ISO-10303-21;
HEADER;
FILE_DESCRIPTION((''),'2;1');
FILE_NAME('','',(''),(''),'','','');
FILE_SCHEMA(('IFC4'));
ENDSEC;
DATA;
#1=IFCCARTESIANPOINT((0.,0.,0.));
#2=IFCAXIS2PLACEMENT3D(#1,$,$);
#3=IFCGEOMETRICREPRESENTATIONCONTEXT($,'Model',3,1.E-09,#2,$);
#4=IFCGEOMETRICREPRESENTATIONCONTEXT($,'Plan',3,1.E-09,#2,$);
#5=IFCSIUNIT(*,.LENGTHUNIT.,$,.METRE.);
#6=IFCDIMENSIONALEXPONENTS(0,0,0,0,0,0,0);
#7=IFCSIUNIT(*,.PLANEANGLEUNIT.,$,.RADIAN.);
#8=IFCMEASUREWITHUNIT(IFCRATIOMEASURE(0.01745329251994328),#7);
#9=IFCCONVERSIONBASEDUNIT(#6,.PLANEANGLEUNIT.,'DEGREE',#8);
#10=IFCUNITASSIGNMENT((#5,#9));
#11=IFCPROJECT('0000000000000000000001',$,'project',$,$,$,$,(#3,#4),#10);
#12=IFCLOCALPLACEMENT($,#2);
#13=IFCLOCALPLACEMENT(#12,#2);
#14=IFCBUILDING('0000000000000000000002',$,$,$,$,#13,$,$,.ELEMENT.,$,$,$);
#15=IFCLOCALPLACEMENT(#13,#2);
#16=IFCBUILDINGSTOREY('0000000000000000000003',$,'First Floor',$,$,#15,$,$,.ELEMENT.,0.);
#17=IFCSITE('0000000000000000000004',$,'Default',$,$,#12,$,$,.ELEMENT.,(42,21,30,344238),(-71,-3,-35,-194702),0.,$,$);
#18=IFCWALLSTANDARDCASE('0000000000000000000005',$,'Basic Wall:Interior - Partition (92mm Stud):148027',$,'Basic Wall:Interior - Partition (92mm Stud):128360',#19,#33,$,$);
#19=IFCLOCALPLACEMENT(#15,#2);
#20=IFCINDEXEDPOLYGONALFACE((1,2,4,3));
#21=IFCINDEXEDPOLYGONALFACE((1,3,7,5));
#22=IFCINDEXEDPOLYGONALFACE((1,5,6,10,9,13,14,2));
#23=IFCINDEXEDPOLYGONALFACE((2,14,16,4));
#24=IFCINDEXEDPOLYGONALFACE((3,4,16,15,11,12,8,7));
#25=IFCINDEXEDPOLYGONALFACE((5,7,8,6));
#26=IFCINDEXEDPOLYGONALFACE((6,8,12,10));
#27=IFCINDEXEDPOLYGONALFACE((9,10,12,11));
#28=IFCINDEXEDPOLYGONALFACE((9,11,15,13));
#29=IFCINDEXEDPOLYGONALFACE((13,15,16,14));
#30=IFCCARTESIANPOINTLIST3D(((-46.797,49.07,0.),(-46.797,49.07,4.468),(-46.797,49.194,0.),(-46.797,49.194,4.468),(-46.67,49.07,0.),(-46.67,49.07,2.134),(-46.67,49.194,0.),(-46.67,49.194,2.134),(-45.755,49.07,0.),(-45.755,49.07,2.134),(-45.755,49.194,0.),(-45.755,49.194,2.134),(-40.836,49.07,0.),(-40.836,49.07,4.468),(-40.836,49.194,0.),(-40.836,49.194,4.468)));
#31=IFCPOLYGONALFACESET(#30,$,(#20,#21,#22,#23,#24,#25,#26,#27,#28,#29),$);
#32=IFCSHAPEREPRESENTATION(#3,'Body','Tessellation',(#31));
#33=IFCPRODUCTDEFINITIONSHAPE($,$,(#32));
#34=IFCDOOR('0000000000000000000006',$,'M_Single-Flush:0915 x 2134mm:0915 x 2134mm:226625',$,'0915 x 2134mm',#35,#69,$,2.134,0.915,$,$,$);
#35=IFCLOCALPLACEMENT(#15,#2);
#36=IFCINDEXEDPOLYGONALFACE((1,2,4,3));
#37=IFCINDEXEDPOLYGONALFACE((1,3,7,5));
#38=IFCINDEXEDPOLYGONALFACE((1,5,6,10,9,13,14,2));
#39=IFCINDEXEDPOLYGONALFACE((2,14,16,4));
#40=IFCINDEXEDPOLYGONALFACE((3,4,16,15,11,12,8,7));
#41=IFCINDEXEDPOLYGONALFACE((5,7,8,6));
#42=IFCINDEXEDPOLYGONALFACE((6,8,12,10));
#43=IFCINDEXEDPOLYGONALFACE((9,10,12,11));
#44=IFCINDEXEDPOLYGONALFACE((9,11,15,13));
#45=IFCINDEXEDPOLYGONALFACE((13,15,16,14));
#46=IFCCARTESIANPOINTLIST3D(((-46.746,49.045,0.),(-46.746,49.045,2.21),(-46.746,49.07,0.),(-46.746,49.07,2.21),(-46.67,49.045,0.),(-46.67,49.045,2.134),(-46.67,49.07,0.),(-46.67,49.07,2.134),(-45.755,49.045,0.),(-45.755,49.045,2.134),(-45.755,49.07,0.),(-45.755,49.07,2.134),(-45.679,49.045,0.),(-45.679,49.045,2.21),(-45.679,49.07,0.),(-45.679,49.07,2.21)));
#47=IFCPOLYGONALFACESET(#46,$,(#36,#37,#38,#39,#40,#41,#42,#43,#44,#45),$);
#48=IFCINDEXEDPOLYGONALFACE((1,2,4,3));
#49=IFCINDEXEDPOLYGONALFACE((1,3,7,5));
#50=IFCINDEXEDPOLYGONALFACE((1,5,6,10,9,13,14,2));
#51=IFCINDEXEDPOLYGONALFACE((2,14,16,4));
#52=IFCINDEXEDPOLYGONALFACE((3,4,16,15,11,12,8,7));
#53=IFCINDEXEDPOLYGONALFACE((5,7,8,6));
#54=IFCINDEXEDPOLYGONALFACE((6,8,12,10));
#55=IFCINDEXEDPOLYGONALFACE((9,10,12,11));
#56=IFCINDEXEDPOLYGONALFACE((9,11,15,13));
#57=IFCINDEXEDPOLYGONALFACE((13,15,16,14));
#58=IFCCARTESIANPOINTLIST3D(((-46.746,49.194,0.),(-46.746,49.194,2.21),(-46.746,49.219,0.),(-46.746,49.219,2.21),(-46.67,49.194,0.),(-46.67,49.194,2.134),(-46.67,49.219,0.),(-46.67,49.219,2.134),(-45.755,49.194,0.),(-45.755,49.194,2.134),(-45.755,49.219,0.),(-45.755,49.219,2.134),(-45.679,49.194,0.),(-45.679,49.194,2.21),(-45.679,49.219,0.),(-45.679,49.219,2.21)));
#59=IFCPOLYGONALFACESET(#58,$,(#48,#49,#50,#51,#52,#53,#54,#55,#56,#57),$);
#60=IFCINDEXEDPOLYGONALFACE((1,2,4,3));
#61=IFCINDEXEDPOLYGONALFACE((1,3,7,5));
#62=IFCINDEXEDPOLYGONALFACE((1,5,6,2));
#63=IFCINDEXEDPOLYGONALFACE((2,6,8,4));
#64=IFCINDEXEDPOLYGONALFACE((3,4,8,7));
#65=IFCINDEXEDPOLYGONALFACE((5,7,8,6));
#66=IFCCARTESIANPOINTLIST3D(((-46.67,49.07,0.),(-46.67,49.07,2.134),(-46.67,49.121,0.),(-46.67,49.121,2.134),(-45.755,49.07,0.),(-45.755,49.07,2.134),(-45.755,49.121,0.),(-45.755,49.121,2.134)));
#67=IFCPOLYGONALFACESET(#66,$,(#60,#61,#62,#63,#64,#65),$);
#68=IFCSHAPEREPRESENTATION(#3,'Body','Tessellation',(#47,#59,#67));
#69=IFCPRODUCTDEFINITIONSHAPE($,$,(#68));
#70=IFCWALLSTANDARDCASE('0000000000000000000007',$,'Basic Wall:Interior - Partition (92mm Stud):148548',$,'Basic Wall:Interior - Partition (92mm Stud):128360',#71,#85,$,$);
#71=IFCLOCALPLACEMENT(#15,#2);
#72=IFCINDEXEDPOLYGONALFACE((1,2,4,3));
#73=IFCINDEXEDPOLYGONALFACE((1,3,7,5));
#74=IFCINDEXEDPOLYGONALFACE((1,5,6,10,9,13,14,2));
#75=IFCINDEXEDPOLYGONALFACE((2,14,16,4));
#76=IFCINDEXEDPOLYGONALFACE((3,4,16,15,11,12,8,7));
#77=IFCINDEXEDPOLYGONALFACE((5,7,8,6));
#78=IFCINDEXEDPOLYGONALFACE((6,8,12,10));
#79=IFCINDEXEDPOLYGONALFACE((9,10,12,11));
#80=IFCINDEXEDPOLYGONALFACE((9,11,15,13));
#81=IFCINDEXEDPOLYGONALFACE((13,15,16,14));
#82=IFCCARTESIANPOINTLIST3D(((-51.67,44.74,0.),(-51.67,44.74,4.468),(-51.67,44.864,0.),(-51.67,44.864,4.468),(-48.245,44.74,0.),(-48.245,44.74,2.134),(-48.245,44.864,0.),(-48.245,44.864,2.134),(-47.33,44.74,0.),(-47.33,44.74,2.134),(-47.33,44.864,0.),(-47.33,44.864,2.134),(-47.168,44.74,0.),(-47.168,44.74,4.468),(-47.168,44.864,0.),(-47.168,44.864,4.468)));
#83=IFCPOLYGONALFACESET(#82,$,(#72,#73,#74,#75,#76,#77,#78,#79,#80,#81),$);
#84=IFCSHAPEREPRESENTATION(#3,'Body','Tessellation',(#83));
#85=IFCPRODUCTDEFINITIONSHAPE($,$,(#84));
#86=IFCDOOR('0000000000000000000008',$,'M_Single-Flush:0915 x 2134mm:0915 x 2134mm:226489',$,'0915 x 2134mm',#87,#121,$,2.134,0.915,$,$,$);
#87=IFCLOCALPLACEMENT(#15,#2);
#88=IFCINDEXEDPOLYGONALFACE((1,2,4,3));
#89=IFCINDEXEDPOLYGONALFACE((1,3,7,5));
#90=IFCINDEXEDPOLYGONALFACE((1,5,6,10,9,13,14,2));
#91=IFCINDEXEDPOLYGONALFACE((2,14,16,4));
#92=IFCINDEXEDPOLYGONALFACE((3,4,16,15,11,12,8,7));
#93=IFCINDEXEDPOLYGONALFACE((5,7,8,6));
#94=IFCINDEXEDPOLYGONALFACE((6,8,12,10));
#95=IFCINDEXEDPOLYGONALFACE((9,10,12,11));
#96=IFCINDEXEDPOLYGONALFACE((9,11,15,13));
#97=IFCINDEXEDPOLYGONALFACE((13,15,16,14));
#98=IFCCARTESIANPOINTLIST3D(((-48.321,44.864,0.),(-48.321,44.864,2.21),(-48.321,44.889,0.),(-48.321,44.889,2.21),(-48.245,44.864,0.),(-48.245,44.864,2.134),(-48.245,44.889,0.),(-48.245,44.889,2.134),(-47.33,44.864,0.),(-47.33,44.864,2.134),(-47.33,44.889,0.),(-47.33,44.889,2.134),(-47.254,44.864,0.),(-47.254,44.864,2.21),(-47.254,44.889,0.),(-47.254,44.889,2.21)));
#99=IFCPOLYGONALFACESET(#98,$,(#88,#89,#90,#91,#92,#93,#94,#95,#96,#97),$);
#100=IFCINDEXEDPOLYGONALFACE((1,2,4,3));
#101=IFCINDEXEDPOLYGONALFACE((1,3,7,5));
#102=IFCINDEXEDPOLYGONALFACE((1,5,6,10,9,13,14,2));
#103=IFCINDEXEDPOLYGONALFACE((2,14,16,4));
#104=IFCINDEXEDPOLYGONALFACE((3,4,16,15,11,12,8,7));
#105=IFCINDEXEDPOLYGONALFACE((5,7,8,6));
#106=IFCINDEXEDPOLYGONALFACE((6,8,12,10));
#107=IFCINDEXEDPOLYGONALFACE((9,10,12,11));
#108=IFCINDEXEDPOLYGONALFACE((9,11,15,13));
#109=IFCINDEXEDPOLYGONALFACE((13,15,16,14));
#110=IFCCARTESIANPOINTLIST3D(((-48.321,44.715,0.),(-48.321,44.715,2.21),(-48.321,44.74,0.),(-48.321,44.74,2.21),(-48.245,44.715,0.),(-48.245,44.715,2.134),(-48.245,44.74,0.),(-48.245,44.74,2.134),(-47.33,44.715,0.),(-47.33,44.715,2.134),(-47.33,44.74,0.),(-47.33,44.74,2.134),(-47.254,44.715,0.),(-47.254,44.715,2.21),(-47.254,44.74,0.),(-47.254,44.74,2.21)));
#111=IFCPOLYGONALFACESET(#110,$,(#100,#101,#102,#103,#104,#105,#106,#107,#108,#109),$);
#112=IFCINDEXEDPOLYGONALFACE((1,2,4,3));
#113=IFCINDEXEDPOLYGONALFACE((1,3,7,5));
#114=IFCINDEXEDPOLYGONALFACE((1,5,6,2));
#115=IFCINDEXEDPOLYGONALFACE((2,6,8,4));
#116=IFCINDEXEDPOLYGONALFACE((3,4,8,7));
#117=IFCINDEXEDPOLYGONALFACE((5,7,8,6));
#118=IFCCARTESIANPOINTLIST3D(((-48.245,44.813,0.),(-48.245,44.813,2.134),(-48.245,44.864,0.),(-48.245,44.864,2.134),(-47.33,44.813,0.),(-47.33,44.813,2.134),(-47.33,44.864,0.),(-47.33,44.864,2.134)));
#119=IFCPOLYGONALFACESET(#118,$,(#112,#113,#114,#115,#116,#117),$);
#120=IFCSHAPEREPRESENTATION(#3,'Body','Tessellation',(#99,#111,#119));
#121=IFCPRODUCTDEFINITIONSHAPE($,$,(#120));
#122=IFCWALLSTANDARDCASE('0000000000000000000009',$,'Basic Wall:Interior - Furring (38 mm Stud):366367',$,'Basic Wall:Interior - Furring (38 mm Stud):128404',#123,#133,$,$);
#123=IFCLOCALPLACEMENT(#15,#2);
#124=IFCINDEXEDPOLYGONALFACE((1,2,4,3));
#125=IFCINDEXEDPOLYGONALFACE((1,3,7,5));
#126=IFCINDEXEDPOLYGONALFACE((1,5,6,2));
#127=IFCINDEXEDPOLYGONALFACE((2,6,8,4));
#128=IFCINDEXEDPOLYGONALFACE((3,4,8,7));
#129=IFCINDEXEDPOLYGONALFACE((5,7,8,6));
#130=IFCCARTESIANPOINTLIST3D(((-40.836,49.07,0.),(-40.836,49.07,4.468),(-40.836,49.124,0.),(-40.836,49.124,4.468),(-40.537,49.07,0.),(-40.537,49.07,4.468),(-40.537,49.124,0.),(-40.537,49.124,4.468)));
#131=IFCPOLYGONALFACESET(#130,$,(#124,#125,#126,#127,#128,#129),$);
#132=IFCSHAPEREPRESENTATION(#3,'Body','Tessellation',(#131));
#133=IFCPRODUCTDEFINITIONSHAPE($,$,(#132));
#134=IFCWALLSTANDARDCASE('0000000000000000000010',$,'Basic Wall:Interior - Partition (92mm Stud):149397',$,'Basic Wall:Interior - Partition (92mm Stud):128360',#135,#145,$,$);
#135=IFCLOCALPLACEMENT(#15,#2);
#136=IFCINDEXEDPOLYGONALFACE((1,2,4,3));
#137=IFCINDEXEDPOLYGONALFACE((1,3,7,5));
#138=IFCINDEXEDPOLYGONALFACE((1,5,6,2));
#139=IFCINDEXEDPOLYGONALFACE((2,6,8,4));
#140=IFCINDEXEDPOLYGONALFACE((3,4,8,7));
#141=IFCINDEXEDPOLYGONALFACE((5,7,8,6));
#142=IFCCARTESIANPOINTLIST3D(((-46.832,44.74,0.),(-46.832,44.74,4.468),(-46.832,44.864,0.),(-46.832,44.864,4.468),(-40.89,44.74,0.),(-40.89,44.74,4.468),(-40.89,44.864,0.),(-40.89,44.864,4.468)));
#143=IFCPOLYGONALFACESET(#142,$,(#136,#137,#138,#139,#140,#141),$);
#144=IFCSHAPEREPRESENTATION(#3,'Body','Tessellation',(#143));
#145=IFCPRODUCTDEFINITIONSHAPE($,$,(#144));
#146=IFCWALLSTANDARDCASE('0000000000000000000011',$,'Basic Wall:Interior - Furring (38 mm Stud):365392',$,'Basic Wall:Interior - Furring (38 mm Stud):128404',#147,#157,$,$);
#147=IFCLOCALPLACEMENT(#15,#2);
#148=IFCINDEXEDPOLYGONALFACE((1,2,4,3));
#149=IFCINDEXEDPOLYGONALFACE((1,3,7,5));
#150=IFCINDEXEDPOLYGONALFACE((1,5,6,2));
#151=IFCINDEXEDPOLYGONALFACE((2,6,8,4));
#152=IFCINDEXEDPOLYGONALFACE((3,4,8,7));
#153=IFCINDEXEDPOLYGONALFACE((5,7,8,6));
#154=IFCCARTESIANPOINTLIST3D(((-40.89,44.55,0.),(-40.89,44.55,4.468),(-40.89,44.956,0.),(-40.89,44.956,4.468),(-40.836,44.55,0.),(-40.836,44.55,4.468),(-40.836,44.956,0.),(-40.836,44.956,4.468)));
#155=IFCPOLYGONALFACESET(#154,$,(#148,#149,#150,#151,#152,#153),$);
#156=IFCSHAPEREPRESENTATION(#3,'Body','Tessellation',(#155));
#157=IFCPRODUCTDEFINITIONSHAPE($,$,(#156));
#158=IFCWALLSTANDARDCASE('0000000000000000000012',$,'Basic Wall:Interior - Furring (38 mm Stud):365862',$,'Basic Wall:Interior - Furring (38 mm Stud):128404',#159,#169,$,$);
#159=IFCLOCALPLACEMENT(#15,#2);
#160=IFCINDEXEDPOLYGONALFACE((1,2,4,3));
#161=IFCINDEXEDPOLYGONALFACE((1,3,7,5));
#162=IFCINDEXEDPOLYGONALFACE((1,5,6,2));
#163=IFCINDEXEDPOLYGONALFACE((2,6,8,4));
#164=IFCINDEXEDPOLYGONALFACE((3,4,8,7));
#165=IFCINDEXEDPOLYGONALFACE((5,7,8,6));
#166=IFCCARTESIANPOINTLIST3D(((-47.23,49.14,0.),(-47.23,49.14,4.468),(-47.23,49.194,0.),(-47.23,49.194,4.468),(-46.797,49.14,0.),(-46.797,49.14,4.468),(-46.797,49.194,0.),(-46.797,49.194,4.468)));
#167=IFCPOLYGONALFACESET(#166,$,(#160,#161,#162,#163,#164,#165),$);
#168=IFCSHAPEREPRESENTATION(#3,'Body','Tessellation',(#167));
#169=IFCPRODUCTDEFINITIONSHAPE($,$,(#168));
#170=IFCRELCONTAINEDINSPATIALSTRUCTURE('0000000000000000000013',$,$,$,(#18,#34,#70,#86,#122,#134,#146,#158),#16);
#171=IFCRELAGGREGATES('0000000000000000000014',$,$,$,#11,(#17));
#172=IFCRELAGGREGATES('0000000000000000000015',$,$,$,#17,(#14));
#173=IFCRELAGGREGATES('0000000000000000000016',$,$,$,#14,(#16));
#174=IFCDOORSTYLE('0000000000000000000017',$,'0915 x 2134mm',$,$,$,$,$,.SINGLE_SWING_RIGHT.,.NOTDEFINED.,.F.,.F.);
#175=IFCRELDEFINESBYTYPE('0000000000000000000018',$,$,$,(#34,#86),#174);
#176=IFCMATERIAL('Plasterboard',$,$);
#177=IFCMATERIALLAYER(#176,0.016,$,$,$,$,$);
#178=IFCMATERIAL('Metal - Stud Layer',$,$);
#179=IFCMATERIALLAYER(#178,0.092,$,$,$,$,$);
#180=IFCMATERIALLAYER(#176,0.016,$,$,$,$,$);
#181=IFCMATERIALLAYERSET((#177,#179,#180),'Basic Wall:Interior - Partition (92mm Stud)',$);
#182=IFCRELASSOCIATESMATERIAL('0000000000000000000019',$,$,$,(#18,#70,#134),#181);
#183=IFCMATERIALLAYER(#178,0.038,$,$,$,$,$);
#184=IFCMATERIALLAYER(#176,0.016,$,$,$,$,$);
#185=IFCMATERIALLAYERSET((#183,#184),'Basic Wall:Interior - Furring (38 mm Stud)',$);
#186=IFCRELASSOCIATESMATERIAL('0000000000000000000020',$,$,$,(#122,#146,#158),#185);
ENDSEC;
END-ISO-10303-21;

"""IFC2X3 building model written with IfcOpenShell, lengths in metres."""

from ifc_helpers import new_model, entity, si_unit, converted_unit, frame, frame_2d, origin, origin_2d_with_axis, place, context, project, spatial, polyline, rectangle, outline, extrude, source, transform, mapped, material, layer, layer_set, layer_usage, type_object, type_shapes, element, fill, save


model = new_model("IFC2X3")

# Units and contexts
model_context = context("Model", 3, precision=1e-09, world=origin())
plan_context = context("Plan", 3, precision=1e-09, world=origin())
ifc_project = project(units=[si_unit("LENGTHUNIT", "METRE"), converted_unit("PLANEANGLEUNIT", "DEGREE", entity("IfcRatioMeasure", 0.01745329251994328), si_unit("PLANEANGLEUNIT", "RADIAN"), dimensions=[0, 0, 0, 0, 0, 0, 0])], contexts=[model_context, plan_context])

# Site, building, storey
site_placement = place(None, origin())
site = spatial("IfcSite", under=ifc_project, at=site_placement, Name="Default", CompositionType="ELEMENT", RefLatitude=(42, 21, 30, 344238), RefLongitude=(-71, -3, -35, -194702), RefElevation=0.0)
building_placement = place(site_placement, origin())
building = spatial("IfcBuilding", under=site, at=building_placement, CompositionType="ELEMENT")
storey_placement = place(building_placement, origin())
storey = spatial("IfcBuildingStorey", under=building, at=storey_placement, Name="First Floor", CompositionType="ELEMENT", Elevation=0.0)

# Walls, openings, doors
ifc_material_1 = material(Name="Plasterboard")
ifc_layer_1 = layer(ifc_material_1, 0.016)
ifc_material_2 = material(Name="Metal - Stud Layer")
ifc_layer_2 = layer(ifc_material_2, 0.092)
ifc_layer_3 = layer(ifc_material_1, 0.016)
ifc_layer_set_1 = layer_set([ifc_layer_1, ifc_layer_2, ifc_layer_3], Name="Basic Wall:Interior - Partition (92mm Stud)")
ifc_layer_usage_1 = layer_usage(ifc_layer_set_1, "AXIS2", "NEGATIVE", 0.062)
wall_1_placement = place(storey_placement, frame((-40.836, 49.132, 0.0), z_axis=(0.0, 0.0, 1.0), x_axis=(-1.0, 0.0, 0.0)))
wall_1 = element("IfcWallStandardCase", 1, at=wall_1_placement, inside=storey, material=ifc_layer_usage_1, Name="Basic Wall:Interior - Partition (92mm Stud):148027", ObjectType="Basic Wall:Interior - Partition (92mm Stud):128360", context=model_context, shape_type="SweptSolid", body=[
    extrude(rectangle(XDim=5.961, YDim=0.124, at=frame_2d((2.9805, 0.0), x_axis=(-1.0, 0.0))), origin(), (0.0, 0.0, 1.0), 4.468),
])
opening_1_placement = place(wall_1_placement, frame((4.919, -0.062, 0.0)))
opening_1 = element("IfcOpeningElement", 2, at=opening_1_placement, cuts=wall_1, ObjectType="Opening", context=model_context, shape_type="SweptSolid", body=[
    extrude(rectangle(XDim=0.915, YDim=2.134, at=frame_2d((1.067, 0.4575), x_axis=(0.0, 1.0))), frame((0.0, 0.0, 0.0), z_axis=(0.0, 1.0, 0.0), x_axis=(0.0, 0.0, 1.0)), (0.0, 0.0, 1.0), 0.124),
])
door_style_1 = type_object("IfcDoorStyle", Name="0915 x 2134mm", ConstructionType="NOTDEFINED", OperationType="SINGLE_SWING_RIGHT", ParameterTakesPrecedence=False, Sizeable=False)
shared_shape_1 = source(origin(), model_context, "Body", "SweptSolid", [
    extrude(outline(polyline([(-0.5335, -1.124), (0.5335, -1.124), (0.5335, 1.086), (0.4575, 1.086), (0.4575, -1.048), (-0.4575, -1.048), (-0.4575, 1.086), (-0.5335, 1.086), (-0.5335, -1.124)])), frame((0.4575, 0.124, 1.086), z_axis=(0.0, 1.0, 0.0), x_axis=(1.0, 0.0, 0.0)), (0.0, 0.0, 1.0), 0.025),
    extrude(outline(polyline([(-1.124, -0.5335), (1.086, -0.5335), (1.086, -0.4575), (-1.048, -0.4575), (-1.048, 0.4575), (1.086, 0.4575), (1.086, 0.5335), (-1.124, 0.5335), (-1.124, -0.5335)])), frame((0.4575, -0.025, 1.086), z_axis=(0.0, 1.0, 0.0), x_axis=(0.0, 0.0, -1.0)), (0.0, 0.0, 1.0), 0.025),
    extrude(rectangle(XDim=0.051, YDim=0.915, at=origin_2d_with_axis()), frame((0.4575, 0.0985, 0.0), z_axis=(0.0, 0.0, 1.0), x_axis=(0.0, 1.0, 0.0)), (0.0, 0.0, 1.0), 2.134),
])
type_shapes(door_style_1, [shared_shape_1])
door_1_placement = place(opening_1_placement, origin())
door_1 = element("IfcDoor", 3, at=door_1_placement, inside=storey, type_object=door_style_1, Name="M_Single-Flush:0915 x 2134mm:0915 x 2134mm:226625", ObjectType="0915 x 2134mm", OverallHeight=2.134, OverallWidth=0.915, context=model_context, shape_type="MappedRepresentation", body=[
    mapped(shared_shape_1, transform((0.0, 0.0, 0.0), scale=1.0)),
])
fill(opening_1, door_1)
wall_2_placement = place(storey_placement, frame((-47.168, 44.802, 0.0), z_axis=(0.0, 0.0, 1.0), x_axis=(-1.0, 0.0, 0.0)))
wall_2 = element("IfcWallStandardCase", 4, at=wall_2_placement, inside=storey, material=ifc_layer_usage_1, Name="Basic Wall:Interior - Partition (92mm Stud):148548", ObjectType="Basic Wall:Interior - Partition (92mm Stud):128360", context=model_context, shape_type="SweptSolid", body=[
    extrude(rectangle(XDim=4.502, YDim=0.124, at=frame_2d((2.251, 0.0), x_axis=(-1.0, 0.0))), origin(), (0.0, 0.0, 1.0), 4.468),
])
opening_2_placement = place(wall_2_placement, frame((1.077, 0.062, 0.0)))
opening_2 = element("IfcOpeningElement", 5, at=opening_2_placement, cuts=wall_2, ObjectType="Opening", context=model_context, shape_type="SweptSolid", body=[
    extrude(rectangle(XDim=0.915, YDim=2.134, at=frame_2d((1.067, 0.4575), x_axis=(0.0, 1.0))), frame((0.0, 0.0, 0.0), z_axis=(0.0, -1.0, 0.0), x_axis=(0.0, 0.0, 1.0)), (0.0, 0.0, 1.0), 0.124),
])
door_2_placement = place(opening_2_placement, frame((0.0, 0.0, 0.0), z_axis=(0.0, 0.0, 1.0), x_axis=(-1.0, 0.0, 0.0)))
door_2 = element("IfcDoor", 6, at=door_2_placement, inside=storey, type_object=door_style_1, Name="M_Single-Flush:0915 x 2134mm:0915 x 2134mm:226489", ObjectType="0915 x 2134mm", OverallHeight=2.134, OverallWidth=0.915, context=model_context, shape_type="MappedRepresentation", body=[
    mapped(shared_shape_1, transform((0.0, 0.0, 0.0), scale=1.0)),
])
fill(opening_2, door_2)

# Walls
ifc_layer_4 = layer(ifc_material_2, 0.038)
ifc_layer_5 = layer(ifc_material_1, 0.016)
ifc_layer_set_2 = layer_set([ifc_layer_4, ifc_layer_5], Name="Basic Wall:Interior - Furring (38 mm Stud)")
ifc_layer_usage_2 = layer_usage(ifc_layer_set_2, "AXIS2", "NEGATIVE", 0.027)
wall_3_placement = place(storey_placement, frame((-40.836, 49.097, 0.0)))
element("IfcWallStandardCase", 7, at=wall_3_placement, inside=storey, material=ifc_layer_usage_2, Name="Basic Wall:Interior - Furring (38 mm Stud):366367", ObjectType="Basic Wall:Interior - Furring (38 mm Stud):128404", context=model_context, shape_type="SweptSolid", body=[
    extrude(rectangle(XDim=0.299, YDim=0.054, at=frame_2d((0.1495, 0.0), x_axis=(-1.0, 0.0))), origin(), (0.0, 0.0, 1.0), 4.468),
])
wall_4_placement = place(storey_placement, frame((-40.89, 44.802, 0.0), z_axis=(0.0, 0.0, 1.0), x_axis=(-1.0, 0.0, 0.0)))
element("IfcWallStandardCase", 8, at=wall_4_placement, inside=storey, material=ifc_layer_usage_1, Name="Basic Wall:Interior - Partition (92mm Stud):149397", ObjectType="Basic Wall:Interior - Partition (92mm Stud):128360", context=model_context, shape_type="SweptSolid", body=[
    extrude(rectangle(XDim=5.942, YDim=0.124, at=frame_2d((2.971, 0.0), x_axis=(-1.0, 0.0))), origin(), (0.0, 0.0, 1.0), 4.468),
])
wall_5_placement = place(storey_placement, frame((-40.863, 44.956, 0.0), z_axis=(0.0, 0.0, 1.0), x_axis=(0.0, -1.0, 0.0)))
element("IfcWallStandardCase", 9, at=wall_5_placement, inside=storey, material=ifc_layer_usage_2, Name="Basic Wall:Interior - Furring (38 mm Stud):365392", ObjectType="Basic Wall:Interior - Furring (38 mm Stud):128404", context=model_context, shape_type="SweptSolid", body=[
    extrude(rectangle(XDim=0.406, YDim=0.054, at=frame_2d((0.203, 0.0), x_axis=(-1.0, 0.0))), origin(), (0.0, 0.0, 1.0), 4.468),
])
wall_6_placement = place(storey_placement, frame((-46.797, 49.167, 0.0), z_axis=(0.0, 0.0, 1.0), x_axis=(-1.0, 0.0, 0.0)))
element("IfcWallStandardCase", 10, at=wall_6_placement, inside=storey, material=ifc_layer_usage_2, Name="Basic Wall:Interior - Furring (38 mm Stud):365862", ObjectType="Basic Wall:Interior - Furring (38 mm Stud):128404", context=model_context, shape_type="SweptSolid", body=[
    extrude(rectangle(XDim=0.433, YDim=0.054, at=frame_2d((0.2165, 0.0), x_axis=(-1.0, 0.0))), origin(), (0.0, 0.0, 1.0), 4.468),
])

save(model, "model.ifc")
